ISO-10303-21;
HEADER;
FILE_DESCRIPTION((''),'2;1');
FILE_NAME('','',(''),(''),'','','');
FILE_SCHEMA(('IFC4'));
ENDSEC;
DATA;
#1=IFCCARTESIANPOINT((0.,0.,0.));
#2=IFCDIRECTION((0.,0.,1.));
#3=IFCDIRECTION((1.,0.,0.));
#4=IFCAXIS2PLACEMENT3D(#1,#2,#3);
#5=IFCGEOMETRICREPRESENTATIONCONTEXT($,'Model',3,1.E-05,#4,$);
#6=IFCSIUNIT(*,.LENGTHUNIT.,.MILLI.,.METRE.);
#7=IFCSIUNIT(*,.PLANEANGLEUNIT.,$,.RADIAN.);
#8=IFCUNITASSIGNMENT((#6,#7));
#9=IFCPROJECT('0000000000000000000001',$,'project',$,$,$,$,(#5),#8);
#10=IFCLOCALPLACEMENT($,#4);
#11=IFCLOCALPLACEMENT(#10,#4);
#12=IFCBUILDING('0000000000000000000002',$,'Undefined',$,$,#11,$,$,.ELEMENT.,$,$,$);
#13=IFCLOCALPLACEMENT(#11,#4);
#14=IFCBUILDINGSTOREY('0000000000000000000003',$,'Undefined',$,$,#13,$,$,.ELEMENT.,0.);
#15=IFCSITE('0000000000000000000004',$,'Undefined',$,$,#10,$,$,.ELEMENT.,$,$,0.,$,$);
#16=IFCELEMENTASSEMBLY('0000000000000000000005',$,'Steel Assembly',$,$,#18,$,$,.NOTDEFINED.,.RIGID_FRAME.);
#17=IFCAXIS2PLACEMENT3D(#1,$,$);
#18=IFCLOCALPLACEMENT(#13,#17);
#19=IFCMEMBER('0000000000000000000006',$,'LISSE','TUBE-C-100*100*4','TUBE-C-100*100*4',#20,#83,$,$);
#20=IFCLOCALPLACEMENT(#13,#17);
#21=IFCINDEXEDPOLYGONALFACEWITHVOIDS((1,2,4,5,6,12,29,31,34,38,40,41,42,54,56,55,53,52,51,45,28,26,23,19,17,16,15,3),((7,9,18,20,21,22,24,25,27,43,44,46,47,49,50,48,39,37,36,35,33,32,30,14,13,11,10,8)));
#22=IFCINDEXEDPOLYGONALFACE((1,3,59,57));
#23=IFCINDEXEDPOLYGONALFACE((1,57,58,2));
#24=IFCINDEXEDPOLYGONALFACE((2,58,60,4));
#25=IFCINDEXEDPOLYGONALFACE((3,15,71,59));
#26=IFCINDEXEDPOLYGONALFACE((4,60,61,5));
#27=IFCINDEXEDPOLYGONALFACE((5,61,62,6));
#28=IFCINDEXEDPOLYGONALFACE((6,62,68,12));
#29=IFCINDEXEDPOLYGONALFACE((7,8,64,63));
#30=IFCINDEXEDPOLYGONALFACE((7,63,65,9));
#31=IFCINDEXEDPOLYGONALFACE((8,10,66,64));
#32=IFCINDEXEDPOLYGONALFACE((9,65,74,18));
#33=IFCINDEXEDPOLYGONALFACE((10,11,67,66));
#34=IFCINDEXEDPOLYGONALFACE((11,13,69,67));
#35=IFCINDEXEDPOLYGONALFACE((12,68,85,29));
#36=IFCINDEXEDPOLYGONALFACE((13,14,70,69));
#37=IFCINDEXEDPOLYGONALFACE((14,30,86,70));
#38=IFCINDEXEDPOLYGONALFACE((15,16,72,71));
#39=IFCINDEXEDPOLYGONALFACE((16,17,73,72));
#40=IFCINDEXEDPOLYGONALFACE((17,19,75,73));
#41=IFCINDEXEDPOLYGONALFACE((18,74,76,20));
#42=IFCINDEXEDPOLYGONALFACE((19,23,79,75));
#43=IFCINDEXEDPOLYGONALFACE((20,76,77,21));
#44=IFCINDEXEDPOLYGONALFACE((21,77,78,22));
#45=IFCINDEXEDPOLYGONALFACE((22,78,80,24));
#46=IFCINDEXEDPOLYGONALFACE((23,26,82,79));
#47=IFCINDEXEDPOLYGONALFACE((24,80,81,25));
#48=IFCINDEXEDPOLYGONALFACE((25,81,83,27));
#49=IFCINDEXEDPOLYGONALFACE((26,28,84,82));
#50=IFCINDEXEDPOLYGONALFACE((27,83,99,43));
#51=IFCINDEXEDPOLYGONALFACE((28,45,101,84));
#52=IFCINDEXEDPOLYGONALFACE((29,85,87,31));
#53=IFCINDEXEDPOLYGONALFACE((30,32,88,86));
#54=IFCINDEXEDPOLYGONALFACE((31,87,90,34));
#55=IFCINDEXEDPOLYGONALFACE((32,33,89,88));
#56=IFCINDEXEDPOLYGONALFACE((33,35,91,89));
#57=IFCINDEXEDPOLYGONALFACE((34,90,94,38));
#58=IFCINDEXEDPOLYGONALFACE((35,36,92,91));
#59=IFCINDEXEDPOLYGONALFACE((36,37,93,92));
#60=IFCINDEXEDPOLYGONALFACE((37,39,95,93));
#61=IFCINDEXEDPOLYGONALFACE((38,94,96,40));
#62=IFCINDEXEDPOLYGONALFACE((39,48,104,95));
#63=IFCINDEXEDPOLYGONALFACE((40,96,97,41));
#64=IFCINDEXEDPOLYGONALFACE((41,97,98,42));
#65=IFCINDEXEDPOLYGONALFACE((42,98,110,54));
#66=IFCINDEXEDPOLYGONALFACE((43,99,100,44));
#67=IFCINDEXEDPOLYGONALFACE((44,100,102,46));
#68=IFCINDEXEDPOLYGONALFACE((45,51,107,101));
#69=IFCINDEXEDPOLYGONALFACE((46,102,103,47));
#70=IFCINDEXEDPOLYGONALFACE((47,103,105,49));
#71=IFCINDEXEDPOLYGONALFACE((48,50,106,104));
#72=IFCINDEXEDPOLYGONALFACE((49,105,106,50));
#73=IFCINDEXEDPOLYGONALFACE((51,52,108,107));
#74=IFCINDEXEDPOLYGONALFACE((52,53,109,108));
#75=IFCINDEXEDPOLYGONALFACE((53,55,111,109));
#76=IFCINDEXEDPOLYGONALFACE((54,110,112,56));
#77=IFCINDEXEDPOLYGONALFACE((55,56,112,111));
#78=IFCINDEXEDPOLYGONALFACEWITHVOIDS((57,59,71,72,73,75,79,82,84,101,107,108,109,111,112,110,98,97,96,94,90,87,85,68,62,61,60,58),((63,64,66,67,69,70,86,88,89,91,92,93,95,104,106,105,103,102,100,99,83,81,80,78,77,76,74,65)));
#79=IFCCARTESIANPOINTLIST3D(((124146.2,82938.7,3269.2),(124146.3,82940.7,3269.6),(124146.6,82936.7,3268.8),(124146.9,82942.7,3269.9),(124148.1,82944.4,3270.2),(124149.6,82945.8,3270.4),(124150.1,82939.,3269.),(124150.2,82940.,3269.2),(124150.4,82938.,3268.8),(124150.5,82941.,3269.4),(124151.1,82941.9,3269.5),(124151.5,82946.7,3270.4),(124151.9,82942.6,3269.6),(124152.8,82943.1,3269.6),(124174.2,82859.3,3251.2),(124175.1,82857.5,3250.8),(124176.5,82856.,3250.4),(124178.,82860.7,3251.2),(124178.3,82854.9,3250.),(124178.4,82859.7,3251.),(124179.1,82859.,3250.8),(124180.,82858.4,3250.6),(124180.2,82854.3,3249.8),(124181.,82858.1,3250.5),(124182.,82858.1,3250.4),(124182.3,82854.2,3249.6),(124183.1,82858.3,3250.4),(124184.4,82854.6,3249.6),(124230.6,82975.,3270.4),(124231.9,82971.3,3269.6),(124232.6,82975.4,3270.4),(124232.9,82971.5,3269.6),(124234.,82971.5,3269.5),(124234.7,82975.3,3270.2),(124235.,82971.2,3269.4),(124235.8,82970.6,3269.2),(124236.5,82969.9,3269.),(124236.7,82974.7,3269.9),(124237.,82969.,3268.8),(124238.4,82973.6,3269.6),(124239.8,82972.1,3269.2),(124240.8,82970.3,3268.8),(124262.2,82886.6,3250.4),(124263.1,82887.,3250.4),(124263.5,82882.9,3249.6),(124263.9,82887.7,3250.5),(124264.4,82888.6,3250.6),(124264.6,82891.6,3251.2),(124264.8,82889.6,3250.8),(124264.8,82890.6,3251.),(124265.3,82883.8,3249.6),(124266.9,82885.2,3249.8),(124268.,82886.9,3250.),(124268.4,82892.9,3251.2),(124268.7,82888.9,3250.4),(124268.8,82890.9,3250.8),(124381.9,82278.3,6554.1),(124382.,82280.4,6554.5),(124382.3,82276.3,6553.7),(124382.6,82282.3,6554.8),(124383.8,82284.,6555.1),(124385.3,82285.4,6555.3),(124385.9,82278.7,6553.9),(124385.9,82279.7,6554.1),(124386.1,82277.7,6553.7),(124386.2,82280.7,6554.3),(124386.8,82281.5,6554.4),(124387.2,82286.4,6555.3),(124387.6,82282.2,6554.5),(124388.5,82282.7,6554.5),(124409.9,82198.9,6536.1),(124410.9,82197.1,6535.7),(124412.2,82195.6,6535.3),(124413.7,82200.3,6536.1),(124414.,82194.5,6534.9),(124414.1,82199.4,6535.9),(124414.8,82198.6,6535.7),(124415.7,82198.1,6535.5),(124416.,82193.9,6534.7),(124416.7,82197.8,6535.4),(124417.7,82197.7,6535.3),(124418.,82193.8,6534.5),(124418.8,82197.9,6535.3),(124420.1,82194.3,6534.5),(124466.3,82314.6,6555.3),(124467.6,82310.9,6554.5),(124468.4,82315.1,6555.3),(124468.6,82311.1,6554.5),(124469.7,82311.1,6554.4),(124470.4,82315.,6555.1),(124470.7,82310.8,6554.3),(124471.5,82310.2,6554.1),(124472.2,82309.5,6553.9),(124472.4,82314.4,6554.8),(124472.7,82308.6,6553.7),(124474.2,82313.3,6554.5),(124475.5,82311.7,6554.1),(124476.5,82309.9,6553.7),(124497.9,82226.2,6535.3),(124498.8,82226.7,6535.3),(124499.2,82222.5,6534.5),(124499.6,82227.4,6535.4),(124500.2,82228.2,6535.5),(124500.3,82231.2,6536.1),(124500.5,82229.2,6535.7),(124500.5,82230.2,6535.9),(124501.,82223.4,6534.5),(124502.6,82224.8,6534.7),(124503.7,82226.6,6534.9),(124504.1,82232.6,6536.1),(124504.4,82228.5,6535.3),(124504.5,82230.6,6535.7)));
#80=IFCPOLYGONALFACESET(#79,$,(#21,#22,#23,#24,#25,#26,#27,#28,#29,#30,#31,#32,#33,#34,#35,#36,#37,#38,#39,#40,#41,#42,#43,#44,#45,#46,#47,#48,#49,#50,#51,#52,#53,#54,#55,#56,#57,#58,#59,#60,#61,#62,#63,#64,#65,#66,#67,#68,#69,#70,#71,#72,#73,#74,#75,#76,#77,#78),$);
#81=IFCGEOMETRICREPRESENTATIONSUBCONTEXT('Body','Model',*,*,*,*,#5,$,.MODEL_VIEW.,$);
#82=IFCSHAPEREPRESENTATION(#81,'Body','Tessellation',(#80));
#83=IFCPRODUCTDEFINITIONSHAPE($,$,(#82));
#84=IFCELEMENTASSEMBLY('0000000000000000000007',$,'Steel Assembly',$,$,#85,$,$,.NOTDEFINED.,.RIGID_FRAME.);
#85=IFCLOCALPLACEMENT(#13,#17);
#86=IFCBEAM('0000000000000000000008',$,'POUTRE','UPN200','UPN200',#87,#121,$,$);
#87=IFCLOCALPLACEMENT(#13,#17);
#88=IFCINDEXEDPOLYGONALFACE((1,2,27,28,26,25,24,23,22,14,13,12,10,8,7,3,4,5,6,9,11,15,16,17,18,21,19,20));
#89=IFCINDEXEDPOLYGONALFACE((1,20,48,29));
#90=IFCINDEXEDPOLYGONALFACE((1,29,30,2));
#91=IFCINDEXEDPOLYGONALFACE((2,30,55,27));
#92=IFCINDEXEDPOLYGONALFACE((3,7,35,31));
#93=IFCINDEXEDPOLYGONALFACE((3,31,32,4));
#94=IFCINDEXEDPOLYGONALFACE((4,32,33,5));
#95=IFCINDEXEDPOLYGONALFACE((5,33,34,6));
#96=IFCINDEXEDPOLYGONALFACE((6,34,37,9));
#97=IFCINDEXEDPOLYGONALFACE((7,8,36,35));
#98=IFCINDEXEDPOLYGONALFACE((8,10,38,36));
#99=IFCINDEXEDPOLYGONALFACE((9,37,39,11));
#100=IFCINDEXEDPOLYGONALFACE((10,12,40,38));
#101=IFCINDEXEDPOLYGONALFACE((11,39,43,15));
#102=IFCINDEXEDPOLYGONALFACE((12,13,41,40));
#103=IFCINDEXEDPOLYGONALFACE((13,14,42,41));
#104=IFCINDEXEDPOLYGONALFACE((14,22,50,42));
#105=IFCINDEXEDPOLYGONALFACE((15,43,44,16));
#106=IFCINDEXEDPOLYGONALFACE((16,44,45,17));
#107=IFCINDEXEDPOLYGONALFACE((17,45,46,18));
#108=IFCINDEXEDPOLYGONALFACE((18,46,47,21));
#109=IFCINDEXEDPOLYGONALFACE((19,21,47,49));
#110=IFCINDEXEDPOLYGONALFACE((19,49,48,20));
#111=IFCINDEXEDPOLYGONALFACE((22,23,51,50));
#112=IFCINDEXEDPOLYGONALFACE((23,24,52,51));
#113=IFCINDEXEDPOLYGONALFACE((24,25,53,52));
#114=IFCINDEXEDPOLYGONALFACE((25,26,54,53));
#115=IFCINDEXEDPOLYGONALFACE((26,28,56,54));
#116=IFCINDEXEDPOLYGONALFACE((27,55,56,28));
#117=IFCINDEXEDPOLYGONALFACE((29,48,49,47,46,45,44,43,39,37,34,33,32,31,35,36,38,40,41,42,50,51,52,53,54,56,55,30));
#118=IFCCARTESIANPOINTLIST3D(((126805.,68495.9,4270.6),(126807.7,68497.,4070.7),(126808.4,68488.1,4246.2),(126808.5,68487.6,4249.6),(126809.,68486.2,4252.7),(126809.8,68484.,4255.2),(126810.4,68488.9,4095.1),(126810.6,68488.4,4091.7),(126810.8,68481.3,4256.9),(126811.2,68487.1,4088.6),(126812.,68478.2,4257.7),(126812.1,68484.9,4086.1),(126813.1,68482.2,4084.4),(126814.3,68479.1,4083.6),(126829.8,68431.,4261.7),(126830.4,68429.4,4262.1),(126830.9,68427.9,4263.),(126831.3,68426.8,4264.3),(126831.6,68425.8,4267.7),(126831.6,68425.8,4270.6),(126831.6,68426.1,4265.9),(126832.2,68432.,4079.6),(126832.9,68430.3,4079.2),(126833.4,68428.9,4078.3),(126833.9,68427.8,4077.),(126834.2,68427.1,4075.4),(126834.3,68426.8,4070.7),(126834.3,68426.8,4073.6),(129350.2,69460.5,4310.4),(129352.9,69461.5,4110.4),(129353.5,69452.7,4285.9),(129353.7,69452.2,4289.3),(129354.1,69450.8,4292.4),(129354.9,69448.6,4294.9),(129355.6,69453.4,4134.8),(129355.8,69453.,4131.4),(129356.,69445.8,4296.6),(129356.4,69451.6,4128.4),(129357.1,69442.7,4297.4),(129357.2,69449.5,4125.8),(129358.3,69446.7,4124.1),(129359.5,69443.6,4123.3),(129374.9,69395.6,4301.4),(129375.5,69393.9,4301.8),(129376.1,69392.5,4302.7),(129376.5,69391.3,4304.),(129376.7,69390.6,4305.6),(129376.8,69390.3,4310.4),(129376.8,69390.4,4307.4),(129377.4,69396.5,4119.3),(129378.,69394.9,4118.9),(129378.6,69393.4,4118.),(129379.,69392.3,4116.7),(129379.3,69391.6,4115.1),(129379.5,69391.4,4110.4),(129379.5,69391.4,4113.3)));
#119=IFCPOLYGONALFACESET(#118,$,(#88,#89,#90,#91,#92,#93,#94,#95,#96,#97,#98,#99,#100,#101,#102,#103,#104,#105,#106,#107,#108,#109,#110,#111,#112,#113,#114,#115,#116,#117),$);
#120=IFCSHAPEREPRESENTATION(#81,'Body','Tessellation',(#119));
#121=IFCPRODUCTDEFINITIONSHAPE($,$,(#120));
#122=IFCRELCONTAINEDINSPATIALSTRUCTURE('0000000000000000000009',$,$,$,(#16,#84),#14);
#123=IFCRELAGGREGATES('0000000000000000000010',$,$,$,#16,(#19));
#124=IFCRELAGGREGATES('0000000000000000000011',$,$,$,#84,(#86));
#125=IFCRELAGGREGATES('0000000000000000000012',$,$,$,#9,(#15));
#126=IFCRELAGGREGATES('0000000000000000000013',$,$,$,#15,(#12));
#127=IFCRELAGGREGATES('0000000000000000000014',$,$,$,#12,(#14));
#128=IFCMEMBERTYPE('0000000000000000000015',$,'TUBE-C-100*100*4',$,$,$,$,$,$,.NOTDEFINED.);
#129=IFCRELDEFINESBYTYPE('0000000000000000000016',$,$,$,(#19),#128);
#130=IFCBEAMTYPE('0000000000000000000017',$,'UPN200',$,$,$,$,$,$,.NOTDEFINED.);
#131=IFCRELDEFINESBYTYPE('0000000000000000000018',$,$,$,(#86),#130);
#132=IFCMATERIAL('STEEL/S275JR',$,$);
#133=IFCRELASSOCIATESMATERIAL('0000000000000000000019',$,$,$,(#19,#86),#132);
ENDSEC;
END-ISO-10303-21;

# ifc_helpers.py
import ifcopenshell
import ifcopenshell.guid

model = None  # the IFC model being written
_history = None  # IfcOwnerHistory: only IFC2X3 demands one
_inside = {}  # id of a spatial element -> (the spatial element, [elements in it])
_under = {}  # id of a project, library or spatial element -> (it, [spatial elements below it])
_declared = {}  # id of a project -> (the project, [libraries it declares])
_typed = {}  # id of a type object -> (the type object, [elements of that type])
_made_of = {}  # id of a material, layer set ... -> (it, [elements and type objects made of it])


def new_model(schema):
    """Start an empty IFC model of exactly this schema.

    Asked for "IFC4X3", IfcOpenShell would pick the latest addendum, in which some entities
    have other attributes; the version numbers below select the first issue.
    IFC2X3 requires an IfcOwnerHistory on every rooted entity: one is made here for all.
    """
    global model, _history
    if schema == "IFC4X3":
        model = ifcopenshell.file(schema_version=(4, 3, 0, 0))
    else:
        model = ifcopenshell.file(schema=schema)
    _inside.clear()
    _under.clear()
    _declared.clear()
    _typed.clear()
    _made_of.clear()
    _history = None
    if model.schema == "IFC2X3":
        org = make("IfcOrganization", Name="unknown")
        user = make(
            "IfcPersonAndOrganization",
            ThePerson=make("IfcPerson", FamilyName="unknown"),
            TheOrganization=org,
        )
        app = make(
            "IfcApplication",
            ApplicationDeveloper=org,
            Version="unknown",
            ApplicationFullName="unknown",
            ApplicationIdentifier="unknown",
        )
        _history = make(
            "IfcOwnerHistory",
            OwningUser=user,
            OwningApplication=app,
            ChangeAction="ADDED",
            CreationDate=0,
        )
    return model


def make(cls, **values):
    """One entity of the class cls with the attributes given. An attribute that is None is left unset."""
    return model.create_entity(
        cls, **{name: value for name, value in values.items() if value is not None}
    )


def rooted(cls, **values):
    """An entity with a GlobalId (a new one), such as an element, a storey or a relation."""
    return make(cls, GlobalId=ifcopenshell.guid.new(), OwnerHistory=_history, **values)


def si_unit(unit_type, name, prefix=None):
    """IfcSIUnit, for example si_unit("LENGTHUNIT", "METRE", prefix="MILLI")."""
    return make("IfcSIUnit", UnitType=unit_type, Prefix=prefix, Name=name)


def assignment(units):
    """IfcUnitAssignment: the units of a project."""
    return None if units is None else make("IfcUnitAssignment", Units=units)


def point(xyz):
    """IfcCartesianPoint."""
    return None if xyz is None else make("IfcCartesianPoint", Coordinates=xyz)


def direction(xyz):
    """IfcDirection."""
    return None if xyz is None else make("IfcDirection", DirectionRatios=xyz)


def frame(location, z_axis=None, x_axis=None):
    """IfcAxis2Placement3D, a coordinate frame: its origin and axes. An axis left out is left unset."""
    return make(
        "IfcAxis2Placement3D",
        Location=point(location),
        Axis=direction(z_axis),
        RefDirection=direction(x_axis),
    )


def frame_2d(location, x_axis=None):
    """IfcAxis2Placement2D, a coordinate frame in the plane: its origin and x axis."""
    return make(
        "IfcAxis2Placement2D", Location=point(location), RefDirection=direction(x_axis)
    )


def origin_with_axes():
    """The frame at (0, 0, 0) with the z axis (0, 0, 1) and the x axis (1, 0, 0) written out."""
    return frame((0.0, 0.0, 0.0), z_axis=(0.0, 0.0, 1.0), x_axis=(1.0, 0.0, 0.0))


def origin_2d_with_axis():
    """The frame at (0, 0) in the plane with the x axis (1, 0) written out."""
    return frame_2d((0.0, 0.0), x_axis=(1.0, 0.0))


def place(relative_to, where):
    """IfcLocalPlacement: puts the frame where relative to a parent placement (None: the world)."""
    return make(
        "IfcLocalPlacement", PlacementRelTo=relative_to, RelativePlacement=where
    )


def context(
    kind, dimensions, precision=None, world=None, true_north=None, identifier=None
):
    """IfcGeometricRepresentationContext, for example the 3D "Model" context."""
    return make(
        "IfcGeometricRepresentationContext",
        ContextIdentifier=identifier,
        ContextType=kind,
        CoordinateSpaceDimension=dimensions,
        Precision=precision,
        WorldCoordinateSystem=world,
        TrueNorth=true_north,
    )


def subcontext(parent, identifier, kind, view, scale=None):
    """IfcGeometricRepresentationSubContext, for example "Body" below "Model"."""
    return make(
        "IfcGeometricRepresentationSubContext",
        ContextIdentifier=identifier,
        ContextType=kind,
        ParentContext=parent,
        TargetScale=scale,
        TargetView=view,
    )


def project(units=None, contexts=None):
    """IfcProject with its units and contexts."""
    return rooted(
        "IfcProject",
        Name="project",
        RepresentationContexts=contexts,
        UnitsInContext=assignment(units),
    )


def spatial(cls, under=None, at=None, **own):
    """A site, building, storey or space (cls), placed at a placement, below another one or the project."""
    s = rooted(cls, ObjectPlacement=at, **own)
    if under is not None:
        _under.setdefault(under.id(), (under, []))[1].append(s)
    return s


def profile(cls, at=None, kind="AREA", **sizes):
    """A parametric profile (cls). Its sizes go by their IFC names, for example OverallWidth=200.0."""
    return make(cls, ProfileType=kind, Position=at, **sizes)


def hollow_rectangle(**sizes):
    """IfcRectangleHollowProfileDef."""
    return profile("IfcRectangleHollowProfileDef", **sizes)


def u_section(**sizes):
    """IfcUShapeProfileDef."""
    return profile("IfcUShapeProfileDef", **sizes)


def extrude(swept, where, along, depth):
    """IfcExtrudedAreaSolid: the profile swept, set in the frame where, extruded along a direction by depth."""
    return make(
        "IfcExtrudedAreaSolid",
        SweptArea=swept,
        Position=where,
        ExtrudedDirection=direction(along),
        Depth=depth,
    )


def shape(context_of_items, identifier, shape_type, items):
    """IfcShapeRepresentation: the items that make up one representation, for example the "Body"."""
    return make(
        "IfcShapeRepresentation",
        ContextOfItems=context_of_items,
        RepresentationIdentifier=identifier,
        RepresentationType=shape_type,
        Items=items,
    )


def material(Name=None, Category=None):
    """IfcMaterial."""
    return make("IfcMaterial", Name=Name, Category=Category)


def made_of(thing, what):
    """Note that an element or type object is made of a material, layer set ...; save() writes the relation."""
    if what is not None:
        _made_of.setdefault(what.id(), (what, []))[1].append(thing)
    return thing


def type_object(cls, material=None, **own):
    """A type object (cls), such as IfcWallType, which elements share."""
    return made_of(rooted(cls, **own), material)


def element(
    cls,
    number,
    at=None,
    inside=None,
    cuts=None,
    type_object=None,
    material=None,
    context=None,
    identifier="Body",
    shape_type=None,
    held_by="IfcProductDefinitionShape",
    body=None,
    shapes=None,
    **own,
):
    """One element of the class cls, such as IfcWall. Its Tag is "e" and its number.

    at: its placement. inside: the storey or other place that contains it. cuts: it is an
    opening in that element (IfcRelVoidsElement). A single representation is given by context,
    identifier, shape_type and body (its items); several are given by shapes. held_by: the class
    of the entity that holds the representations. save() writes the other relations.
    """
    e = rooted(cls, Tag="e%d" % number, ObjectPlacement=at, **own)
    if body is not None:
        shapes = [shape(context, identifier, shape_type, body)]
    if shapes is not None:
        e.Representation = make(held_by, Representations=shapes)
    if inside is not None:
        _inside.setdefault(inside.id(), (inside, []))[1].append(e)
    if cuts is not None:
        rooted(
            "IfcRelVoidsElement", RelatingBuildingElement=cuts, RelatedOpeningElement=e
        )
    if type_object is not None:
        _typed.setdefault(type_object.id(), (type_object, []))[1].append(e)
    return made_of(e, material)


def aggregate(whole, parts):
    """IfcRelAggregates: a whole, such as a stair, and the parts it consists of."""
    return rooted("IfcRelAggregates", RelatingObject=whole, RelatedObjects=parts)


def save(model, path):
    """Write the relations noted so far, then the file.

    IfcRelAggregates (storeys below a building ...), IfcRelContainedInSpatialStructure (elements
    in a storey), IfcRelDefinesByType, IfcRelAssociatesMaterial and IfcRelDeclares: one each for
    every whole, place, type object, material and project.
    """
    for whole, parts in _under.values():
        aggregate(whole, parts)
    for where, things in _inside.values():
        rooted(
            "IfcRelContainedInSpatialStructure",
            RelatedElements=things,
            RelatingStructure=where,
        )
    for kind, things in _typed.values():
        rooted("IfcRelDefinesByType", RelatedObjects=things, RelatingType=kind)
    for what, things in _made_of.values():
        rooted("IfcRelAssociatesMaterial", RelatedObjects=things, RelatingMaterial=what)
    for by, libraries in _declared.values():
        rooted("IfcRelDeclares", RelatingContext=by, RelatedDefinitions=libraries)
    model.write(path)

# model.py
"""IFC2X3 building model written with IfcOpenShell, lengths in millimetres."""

from ifc_helpers import new_model, si_unit, frame, origin_with_axes, origin_2d_with_axis, place, context, subcontext, project, spatial, hollow_rectangle, u_section, extrude, material, type_object, element, aggregate, save


model = new_model("IFC2X3")

# Units and contexts
model_context = context("Model", 3, precision=1e-05, world=origin_with_axes())
body_context = subcontext(model_context, "Body", "Model", "MODEL_VIEW")
ifc_project = project(units=[si_unit("LENGTHUNIT", "METRE", prefix="MILLI"), si_unit("PLANEANGLEUNIT", "RADIAN")], contexts=[model_context])

# Site, building, storey
site_placement = place(None, origin_with_axes())
site = spatial("IfcSite", under=ifc_project, at=site_placement, Name="Undefined", CompositionType="ELEMENT", RefElevation=0.0)
building_placement = place(site_placement, origin_with_axes())
building = spatial("IfcBuilding", under=site, at=building_placement, Name="Undefined", CompositionType="ELEMENT")
storey_placement = place(building_placement, origin_with_axes())
storey = spatial("IfcBuildingStorey", under=building, at=storey_placement, Name="Undefined", CompositionType="ELEMENT", Elevation=0.0)

# Shared definitions
ifc_material = material(Name="STEEL/S275JR")

# Element assembly, member
member_type = type_object("IfcMemberType", Name="TUBE-C-100*100*4", PredefinedType="NOTDEFINED")
assembly_1_placement = place(storey_placement, origin_with_axes())
assembly_1 = element("IfcElementAssembly", 1, at=assembly_1_placement, inside=storey, Name="Steel Assembly", AssemblyPlace="NOTDEFINED", PredefinedType="RIGID_FRAME")
member_1_placement = place(assembly_1_placement, frame((124443.2, 82254.4, 6544.9), z_axis=(0.941802, 0.336168, 0.0), x_axis=(-0.070175, 0.196602, -0.977969)))
member_1 = element("IfcMember", 2, at=member_1_placement, type_object=member_type, material=ifc_material, Name="LISSE", Description="TUBE-C-100*100*4", ObjectType="TUBE-C-100*100*4", context=body_context, shape_type="SweptSolid", body=[
    extrude(hollow_rectangle(XDim=100.0, YDim=100.0, WallThickness=4.0, InnerFilletRadius=4.0, OuterFilletRadius=8.0, at=origin_2d_with_axis()), frame((3358.9, 0.0, 0.0), z_axis=(-1.0, 0.0, 0.0), x_axis=(0.0, -1.0, 0.0)), (0.0, 0.0, 1.0), 3358.9),
])
aggregate(assembly_1, [member_1])

# Element assembly, beam
assembly_2_placement = place(storey_placement, origin_with_axes())
assembly_2 = element("IfcElementAssembly", 3, at=assembly_2_placement, inside=storey, Name="Steel Assembly", AssemblyPlace="NOTDEFINED", PredefinedType="RIGID_FRAME")
beam_type_1 = type_object("IfcBeamType", Name="UPN200", PredefinedType="NOTDEFINED")
beam_1_placement = place(assembly_2_placement, frame((129364.8, 69425.9, 4210.4), z_axis=(0.013644, 0.005171, -0.999894), x_axis=(-0.935003, -0.354338, -0.014591)))
beam_1 = element("IfcBeam", 4, at=beam_1_placement, type_object=beam_type_1, material=ifc_material, Name="POUTRE", Description="UPN200", ObjectType="UPN200", context=body_context, shape_type="SweptSolid", body=[
    extrude(u_section(Depth=200.0, FlangeWidth=75.0, WebThickness=8.5, FlangeThickness=11.5, FilletRadius=11.5, EdgeRadius=6.0, FlangeSlope=0.07983, at=origin_2d_with_axis()), frame((2722.1, 0.0, 0.0), z_axis=(-1.0, 0.0, 0.0), x_axis=(0.0, -1.0, 0.0)), (0.0, 0.0, 1.0), 2722.1),
])
aggregate(assembly_2, [beam_1])

save(model, "model.ifc")
